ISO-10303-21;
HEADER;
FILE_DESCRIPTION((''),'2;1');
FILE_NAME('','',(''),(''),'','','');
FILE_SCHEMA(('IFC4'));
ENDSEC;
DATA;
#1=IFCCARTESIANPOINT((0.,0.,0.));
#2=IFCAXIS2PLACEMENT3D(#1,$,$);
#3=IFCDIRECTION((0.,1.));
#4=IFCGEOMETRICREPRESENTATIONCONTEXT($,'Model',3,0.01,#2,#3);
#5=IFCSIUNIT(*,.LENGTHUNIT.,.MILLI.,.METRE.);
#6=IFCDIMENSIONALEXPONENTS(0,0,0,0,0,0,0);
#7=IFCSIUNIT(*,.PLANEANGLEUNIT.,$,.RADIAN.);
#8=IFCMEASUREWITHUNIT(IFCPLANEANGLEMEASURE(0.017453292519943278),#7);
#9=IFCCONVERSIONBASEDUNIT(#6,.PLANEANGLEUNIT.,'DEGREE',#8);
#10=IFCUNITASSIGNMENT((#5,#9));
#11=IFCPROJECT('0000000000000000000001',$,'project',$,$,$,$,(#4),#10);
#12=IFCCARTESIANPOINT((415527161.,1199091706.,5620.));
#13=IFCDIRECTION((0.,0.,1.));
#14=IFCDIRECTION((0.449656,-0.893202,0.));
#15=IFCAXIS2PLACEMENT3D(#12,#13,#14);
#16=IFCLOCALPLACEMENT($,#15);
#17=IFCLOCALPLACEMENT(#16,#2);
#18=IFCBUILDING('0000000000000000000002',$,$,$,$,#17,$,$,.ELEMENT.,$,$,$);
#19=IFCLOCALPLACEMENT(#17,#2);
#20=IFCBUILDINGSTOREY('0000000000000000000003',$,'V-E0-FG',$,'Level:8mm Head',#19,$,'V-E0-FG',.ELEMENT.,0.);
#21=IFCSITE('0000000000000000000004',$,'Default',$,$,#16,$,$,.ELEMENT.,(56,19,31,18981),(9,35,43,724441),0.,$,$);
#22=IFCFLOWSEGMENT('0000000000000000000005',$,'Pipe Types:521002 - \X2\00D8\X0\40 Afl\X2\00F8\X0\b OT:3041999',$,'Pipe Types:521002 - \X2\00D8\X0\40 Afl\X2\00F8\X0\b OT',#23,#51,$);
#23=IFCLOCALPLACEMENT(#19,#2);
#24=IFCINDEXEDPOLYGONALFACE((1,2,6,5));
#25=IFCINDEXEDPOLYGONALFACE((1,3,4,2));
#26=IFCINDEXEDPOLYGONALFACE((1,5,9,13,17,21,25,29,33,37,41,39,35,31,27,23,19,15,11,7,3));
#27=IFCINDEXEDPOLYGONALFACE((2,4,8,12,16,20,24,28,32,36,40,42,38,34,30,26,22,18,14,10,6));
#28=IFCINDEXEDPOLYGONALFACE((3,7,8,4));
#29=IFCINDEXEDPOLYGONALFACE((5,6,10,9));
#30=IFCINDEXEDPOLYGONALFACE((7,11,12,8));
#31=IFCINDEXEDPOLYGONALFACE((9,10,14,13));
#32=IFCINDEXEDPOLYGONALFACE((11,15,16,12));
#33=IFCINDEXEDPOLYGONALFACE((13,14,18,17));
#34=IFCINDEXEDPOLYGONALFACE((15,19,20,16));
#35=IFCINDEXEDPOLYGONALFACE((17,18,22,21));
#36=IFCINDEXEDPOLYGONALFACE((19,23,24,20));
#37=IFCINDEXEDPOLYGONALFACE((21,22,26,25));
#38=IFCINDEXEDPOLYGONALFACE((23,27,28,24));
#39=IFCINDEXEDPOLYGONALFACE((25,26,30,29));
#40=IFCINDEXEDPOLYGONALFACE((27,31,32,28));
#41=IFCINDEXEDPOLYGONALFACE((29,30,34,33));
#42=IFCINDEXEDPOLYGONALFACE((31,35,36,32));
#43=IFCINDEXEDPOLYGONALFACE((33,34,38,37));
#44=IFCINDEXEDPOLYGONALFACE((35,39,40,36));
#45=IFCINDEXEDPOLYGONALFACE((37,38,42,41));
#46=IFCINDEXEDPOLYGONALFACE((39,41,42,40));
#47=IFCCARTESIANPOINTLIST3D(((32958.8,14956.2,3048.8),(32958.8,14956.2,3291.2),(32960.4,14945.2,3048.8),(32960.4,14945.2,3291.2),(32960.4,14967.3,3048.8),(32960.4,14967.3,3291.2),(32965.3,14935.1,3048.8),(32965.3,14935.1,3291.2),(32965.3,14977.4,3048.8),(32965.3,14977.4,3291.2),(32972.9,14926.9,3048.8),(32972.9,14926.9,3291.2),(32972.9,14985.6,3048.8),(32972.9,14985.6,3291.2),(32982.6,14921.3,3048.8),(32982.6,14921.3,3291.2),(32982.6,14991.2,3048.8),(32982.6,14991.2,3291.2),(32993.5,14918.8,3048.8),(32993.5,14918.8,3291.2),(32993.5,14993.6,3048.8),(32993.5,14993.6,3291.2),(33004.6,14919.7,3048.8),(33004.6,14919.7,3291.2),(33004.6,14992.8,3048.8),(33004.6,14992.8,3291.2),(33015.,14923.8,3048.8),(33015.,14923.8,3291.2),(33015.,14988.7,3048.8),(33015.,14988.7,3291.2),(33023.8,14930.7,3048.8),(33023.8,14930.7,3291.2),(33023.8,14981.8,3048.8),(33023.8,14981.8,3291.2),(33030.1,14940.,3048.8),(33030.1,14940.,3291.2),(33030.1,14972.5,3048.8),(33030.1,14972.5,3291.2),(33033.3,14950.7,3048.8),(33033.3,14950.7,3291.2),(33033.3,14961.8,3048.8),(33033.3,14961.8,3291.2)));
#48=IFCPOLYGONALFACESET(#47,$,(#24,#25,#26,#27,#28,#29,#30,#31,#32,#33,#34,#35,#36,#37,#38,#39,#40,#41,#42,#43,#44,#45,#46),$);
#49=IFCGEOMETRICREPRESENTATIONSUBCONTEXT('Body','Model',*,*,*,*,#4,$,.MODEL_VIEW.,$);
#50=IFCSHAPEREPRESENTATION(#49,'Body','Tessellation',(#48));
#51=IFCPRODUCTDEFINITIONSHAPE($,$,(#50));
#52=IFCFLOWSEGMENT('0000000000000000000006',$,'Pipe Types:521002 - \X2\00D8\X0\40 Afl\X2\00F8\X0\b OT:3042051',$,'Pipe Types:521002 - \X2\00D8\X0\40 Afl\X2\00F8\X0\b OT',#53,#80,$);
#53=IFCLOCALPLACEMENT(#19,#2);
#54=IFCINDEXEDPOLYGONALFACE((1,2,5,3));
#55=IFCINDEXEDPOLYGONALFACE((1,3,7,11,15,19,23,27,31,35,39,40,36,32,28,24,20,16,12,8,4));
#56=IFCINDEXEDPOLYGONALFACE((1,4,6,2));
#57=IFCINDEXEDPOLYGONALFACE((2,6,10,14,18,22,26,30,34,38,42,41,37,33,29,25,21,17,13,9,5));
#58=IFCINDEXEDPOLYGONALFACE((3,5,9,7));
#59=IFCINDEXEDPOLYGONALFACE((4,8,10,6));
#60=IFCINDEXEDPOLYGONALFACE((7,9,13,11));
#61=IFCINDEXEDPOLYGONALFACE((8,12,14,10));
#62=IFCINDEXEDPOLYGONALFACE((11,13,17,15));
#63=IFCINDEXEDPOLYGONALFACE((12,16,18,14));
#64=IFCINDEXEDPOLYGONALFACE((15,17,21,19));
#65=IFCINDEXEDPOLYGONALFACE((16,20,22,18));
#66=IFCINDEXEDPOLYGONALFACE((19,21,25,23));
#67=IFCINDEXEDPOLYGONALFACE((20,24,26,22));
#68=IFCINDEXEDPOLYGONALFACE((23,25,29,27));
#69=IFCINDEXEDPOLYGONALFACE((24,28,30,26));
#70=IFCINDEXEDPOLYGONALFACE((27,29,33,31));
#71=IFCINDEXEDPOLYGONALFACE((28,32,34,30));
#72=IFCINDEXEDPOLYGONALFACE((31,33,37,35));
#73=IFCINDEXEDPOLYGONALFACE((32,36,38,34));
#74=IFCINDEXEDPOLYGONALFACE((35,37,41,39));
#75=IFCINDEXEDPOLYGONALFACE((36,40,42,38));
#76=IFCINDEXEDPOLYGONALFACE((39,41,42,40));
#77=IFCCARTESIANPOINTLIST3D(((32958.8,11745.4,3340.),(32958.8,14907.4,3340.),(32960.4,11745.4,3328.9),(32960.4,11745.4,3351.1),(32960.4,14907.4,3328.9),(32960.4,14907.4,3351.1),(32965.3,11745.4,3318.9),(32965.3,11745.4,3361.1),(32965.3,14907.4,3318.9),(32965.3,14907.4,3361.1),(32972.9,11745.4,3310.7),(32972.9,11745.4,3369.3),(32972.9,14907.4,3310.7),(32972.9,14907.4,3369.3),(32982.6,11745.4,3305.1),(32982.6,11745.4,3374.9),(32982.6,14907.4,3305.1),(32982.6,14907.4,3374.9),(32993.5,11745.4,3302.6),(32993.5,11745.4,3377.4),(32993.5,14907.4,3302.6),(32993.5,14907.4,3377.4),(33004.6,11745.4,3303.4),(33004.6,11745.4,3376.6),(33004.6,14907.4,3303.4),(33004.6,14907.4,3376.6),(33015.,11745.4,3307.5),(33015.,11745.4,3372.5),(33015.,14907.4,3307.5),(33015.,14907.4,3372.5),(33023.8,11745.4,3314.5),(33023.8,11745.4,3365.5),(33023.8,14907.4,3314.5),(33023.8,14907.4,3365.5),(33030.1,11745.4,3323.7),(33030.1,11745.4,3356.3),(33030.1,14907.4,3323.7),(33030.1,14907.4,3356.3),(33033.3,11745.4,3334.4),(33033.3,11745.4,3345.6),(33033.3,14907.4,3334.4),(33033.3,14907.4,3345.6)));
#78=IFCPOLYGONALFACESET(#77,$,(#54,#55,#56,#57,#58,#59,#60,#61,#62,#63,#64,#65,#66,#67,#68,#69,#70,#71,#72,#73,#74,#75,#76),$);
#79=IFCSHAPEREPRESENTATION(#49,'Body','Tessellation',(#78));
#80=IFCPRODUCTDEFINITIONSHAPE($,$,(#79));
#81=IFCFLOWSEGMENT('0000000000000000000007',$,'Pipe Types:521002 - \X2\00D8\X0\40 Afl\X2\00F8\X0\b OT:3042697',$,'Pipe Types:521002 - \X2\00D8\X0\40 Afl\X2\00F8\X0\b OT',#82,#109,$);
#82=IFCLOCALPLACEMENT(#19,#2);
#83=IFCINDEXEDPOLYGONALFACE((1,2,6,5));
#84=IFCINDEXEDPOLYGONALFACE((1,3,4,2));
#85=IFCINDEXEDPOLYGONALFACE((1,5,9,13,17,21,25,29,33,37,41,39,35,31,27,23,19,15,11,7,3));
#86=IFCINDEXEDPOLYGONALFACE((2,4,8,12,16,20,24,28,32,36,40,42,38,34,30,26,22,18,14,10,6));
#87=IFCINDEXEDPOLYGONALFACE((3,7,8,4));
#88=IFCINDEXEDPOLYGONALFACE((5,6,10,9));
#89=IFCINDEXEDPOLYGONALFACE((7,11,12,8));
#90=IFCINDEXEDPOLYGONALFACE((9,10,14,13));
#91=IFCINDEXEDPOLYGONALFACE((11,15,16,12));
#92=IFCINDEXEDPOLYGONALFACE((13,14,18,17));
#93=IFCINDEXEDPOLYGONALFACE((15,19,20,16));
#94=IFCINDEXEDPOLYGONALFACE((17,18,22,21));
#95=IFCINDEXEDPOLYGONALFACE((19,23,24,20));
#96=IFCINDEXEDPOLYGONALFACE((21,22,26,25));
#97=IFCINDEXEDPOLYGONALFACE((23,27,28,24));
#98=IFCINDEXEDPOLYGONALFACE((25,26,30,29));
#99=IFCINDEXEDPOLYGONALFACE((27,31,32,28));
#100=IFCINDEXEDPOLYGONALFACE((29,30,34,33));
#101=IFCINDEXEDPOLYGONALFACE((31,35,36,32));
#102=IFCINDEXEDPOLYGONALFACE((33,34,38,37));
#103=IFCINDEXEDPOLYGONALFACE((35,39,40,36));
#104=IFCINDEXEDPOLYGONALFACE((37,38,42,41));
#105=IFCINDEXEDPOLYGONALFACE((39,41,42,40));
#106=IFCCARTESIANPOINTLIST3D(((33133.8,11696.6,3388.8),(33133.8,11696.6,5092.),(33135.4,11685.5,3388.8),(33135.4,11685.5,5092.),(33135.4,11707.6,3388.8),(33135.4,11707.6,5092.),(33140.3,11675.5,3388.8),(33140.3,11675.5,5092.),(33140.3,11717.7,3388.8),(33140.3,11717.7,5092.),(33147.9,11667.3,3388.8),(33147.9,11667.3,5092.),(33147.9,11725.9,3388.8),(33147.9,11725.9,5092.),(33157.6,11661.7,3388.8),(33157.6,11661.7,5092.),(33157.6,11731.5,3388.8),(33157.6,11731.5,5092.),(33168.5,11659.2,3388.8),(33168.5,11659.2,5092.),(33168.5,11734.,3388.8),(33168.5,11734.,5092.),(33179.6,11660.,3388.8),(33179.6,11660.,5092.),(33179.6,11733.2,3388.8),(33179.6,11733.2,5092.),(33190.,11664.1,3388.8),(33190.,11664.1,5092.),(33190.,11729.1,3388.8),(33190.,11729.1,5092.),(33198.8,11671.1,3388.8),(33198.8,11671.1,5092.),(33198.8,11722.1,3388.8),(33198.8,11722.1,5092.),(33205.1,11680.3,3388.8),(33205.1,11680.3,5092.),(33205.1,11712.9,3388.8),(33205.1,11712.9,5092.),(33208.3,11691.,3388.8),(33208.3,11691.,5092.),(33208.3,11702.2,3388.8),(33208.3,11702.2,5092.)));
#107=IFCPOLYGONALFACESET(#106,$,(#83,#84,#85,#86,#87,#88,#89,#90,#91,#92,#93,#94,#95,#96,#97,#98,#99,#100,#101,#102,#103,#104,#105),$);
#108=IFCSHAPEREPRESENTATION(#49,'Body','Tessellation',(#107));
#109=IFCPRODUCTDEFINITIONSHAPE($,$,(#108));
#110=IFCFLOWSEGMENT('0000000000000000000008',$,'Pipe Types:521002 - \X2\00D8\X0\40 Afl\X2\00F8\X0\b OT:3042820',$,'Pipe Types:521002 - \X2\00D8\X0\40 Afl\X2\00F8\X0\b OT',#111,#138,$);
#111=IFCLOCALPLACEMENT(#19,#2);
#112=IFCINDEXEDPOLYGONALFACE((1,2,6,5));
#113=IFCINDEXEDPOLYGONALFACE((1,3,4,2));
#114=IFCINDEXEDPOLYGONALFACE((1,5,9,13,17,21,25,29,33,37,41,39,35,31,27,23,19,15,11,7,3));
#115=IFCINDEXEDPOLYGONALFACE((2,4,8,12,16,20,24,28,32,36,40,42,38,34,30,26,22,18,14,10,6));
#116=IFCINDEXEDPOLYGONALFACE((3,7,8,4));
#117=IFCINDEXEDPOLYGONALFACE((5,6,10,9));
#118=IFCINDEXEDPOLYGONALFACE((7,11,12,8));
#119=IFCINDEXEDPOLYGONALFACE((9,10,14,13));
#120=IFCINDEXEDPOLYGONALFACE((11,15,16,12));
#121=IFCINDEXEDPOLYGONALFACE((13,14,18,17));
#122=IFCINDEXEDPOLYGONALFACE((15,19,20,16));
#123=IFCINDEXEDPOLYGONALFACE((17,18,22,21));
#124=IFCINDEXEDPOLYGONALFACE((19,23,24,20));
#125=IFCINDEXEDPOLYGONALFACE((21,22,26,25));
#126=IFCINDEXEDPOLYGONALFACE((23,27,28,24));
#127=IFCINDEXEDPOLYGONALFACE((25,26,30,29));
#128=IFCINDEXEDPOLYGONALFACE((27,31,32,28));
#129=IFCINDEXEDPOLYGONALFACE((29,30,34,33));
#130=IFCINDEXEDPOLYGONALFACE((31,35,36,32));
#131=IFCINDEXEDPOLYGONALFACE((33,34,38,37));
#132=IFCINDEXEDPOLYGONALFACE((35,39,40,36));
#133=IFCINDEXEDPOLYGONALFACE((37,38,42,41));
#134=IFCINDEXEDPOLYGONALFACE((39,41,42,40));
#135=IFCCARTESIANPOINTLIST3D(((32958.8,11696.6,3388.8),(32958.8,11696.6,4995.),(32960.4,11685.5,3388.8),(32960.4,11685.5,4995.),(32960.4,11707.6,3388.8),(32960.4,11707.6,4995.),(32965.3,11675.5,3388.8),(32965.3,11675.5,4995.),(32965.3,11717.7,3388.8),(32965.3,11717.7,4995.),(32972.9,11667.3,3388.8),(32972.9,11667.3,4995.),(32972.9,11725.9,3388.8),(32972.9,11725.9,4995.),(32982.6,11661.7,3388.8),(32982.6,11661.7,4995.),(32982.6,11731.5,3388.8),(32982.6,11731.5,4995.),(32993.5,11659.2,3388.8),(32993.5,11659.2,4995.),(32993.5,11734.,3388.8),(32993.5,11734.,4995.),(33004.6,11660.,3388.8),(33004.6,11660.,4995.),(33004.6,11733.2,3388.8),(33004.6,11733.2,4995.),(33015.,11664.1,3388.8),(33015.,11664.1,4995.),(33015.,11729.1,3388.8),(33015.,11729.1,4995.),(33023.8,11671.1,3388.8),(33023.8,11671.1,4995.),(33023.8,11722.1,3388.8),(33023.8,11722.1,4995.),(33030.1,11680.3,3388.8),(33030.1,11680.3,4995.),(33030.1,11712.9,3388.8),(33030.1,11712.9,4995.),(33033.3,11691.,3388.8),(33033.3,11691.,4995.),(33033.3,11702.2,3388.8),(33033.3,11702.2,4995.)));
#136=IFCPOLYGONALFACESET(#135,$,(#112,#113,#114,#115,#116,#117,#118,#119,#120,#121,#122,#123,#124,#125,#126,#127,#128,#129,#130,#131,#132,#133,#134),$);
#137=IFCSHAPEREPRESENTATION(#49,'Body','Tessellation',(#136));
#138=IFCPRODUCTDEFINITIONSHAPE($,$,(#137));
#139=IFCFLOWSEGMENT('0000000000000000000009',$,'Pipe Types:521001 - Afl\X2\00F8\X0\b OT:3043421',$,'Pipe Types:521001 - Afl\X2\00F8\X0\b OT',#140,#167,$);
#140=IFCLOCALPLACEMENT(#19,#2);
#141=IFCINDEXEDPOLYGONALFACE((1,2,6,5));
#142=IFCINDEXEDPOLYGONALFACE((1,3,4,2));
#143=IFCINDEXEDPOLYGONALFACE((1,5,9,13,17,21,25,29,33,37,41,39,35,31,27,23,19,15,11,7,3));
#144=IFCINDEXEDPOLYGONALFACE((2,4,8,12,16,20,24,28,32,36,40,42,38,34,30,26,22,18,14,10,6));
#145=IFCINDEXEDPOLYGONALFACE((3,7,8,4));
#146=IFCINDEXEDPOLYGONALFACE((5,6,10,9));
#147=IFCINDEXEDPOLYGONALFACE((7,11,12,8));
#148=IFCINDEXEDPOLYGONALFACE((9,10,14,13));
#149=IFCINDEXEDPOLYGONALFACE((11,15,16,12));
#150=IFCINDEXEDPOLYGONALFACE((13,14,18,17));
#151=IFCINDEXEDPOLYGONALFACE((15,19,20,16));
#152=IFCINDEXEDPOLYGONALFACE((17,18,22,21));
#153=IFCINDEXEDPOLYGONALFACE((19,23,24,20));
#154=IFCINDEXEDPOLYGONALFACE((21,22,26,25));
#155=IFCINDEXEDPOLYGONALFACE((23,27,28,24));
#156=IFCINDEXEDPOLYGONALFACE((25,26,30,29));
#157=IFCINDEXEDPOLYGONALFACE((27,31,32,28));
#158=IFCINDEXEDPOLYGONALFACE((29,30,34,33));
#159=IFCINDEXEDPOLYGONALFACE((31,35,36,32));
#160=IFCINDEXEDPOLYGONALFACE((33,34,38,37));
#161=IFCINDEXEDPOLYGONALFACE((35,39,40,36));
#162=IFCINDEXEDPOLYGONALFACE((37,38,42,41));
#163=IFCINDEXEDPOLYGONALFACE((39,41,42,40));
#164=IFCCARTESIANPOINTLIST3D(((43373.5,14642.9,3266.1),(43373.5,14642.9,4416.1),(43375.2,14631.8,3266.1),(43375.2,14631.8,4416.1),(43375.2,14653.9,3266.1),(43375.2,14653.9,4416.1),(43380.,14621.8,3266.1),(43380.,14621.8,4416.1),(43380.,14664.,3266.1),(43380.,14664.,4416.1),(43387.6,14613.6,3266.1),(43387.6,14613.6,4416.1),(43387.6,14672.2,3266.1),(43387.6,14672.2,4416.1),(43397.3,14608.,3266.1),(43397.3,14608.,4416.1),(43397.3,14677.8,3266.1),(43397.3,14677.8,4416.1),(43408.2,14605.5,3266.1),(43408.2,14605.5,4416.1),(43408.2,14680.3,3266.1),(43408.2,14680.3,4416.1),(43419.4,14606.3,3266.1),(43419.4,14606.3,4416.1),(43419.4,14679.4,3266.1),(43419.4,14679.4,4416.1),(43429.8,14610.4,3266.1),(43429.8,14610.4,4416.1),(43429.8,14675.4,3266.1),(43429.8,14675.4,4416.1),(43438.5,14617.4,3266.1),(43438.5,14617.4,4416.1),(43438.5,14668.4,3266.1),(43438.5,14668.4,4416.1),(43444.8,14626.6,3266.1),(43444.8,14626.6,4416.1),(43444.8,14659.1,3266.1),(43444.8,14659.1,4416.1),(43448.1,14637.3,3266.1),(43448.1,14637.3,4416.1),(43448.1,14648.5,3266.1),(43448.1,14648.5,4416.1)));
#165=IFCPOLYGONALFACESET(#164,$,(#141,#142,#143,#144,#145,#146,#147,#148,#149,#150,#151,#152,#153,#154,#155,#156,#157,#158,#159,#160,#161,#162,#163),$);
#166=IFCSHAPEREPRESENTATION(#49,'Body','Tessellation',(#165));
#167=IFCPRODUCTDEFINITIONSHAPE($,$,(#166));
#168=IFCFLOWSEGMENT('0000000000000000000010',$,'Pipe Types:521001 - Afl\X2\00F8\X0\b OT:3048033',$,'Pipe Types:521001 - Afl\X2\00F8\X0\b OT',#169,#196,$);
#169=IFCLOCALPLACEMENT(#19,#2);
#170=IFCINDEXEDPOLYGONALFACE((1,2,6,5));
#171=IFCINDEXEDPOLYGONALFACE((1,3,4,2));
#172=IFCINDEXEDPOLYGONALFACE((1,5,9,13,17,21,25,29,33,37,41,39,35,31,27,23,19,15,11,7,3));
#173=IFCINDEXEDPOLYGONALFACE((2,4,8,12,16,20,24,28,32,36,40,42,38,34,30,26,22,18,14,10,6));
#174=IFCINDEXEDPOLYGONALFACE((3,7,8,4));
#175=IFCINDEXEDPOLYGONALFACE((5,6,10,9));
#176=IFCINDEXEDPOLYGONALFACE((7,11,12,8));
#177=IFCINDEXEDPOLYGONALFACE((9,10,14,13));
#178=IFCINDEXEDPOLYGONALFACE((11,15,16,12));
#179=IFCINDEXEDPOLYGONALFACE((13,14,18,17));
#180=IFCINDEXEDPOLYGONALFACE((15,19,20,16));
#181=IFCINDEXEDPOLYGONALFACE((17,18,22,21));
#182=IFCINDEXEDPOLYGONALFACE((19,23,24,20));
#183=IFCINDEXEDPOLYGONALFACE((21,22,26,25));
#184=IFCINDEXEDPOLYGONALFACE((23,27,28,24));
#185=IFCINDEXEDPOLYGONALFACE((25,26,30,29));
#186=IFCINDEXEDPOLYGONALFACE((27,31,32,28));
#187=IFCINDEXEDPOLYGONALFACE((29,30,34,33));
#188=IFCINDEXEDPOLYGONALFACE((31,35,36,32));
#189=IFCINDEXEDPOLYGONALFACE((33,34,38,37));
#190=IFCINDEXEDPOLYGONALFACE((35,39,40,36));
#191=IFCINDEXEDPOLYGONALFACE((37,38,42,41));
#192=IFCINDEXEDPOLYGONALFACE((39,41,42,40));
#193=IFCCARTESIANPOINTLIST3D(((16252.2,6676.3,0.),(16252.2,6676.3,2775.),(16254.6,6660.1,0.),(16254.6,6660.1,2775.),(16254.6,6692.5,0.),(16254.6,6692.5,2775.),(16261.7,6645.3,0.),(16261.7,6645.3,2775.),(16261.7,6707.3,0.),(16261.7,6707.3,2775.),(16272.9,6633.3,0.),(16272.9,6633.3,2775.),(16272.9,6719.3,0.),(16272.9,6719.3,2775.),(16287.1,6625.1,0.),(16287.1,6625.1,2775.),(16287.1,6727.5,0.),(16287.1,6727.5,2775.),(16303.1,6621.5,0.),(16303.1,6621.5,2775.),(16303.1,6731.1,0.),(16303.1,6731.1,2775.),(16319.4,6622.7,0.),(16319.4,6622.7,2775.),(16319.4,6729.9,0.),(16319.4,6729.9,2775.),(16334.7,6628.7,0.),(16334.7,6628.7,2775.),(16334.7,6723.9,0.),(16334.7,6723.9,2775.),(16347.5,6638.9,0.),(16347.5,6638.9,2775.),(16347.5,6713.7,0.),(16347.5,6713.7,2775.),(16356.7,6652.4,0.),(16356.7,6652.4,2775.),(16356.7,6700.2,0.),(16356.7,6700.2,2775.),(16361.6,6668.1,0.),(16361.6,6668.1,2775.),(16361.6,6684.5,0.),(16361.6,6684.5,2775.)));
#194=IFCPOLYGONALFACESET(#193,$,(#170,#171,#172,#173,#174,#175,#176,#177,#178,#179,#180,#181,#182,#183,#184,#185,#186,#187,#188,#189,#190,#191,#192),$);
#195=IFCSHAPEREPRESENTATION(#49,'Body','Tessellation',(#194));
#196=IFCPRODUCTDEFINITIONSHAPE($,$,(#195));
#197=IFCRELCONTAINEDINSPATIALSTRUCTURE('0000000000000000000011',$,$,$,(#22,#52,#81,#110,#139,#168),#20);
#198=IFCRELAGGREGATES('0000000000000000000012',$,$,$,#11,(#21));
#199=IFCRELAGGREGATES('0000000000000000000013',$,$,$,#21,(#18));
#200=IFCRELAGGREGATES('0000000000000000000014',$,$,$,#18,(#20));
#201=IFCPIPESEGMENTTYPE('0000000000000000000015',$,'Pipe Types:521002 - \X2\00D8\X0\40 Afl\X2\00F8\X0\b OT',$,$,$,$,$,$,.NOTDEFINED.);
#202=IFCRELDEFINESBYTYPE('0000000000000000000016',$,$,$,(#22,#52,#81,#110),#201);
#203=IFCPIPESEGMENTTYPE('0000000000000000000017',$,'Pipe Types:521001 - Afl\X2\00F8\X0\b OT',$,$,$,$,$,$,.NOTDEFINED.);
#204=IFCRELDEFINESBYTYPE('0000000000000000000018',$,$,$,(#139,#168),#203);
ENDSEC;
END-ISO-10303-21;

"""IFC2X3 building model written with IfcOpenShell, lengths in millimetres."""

from ifc_helpers import new_model, entity, si_unit, converted_unit, direction, frame, frame_2d, origin, origin_2d_with_axis, place, context, subcontext, project, spatial, circle, extrude, type_object, element, save


model = new_model("IFC2X3")

# Units and contexts
model_context = context("Model", 3, precision=0.01, world=origin(), true_north=direction((0.0, 1.0)))
body_context = subcontext(model_context, "Body", "Model", "MODEL_VIEW")
ifc_project = project(units=[si_unit("LENGTHUNIT", "METRE", prefix="MILLI"), converted_unit("PLANEANGLEUNIT", "DEGREE", entity("IfcPlaneAngleMeasure", 0.017453292519943278), si_unit("PLANEANGLEUNIT", "RADIAN"), dimensions=[0, 0, 0, 0, 0, 0, 0])], contexts=[model_context])

# Site, building, storey
site_placement = place(None, frame((415527161.0, 1199091706.0, 5620.0), z_axis=(0.0, 0.0, 1.0), x_axis=(0.449656, -0.893202, 0.0)))
site = spatial("IfcSite", under=ifc_project, at=site_placement, Name="Default", CompositionType="ELEMENT", RefLatitude=(56, 19, 31, 18981), RefLongitude=(9, 35, 43, 724441), RefElevation=0.0)
building_placement = place(site_placement, origin())
building = spatial("IfcBuilding", under=site, at=building_placement, CompositionType="ELEMENT")
storey_placement = place(building_placement, origin())
storey = spatial("IfcBuildingStorey", under=building, at=storey_placement, Name="V-E0-FG", ObjectType="Level:8mm Head", LongName="V-E0-FG", CompositionType="ELEMENT", Elevation=0.0)

# Flow segments
pipe_segment_type_1 = type_object("IfcPipeSegmentType", Name="Pipe Types:521002 - Ø40 Afløb OT", PredefinedType="NOTDEFINED")
flow_segment_1_placement = place(storey_placement, origin())
element("IfcFlowSegment", 1, at=flow_segment_1_placement, inside=storey, type_object=pipe_segment_type_1, Name="Pipe Types:521002 - Ø40 Afløb OT:3041999", ObjectType="Pipe Types:521002 - Ø40 Afløb OT", context=body_context, shape_type="SweptSolid", body=[
    extrude(circle(Radius=37.5, at=origin_2d_with_axis()), frame((32996.3, 14956.2, 3048.8), z_axis=(0.0, 0.0, 1.0), x_axis=(-1.0, 0.0, 0.0)), (0.0, 0.0, 1.0), 242.3),
])
flow_segment_2_placement = place(storey_placement, origin())
element("IfcFlowSegment", 2, at=flow_segment_2_placement, inside=storey, type_object=pipe_segment_type_1, Name="Pipe Types:521002 - Ø40 Afløb OT:3042051", ObjectType="Pipe Types:521002 - Ø40 Afløb OT", context=body_context, shape_type="SweptSolid", body=[
    extrude(circle(Radius=37.5, at=frame_2d((0.0, 0.0), x_axis=(1.0, 0.0))), frame((32996.3, 11745.4, 3340.0), z_axis=(0.0, 1.0, 0.0), x_axis=(-1.0, 0.0, 0.0)), (0.0, 0.0, 1.0), 3161.9),
])
flow_segment_3_placement = place(storey_placement, origin())
element("IfcFlowSegment", 3, at=flow_segment_3_placement, inside=storey, type_object=pipe_segment_type_1, Name="Pipe Types:521002 - Ø40 Afløb OT:3042697", ObjectType="Pipe Types:521002 - Ø40 Afløb OT", context=body_context, shape_type="SweptSolid", body=[
    extrude(circle(Radius=37.5, at=origin_2d_with_axis()), frame((33171.3, 11696.6, 3388.8), z_axis=(0.0, 0.0, 1.0), x_axis=(-1.0, 0.0, 0.0)), (0.0, 0.0, 1.0), 1703.1),
])
flow_segment_4_placement = place(storey_placement, origin())
element("IfcFlowSegment", 4, at=flow_segment_4_placement, inside=storey, type_object=pipe_segment_type_1, Name="Pipe Types:521002 - Ø40 Afløb OT:3042820", ObjectType="Pipe Types:521002 - Ø40 Afløb OT", context=body_context, shape_type="SweptSolid", body=[
    extrude(circle(Radius=37.5, at=origin_2d_with_axis()), frame((32996.3, 11696.6, 3388.8), z_axis=(0.0, 0.0, 1.0), x_axis=(-1.0, 0.0, 0.0)), (0.0, 0.0, 1.0), 1606.1),
])
pipe_segment_type_2 = type_object("IfcPipeSegmentType", Name="Pipe Types:521001 - Afløb OT", PredefinedType="NOTDEFINED")
flow_segment_5_placement = place(storey_placement, origin())
element("IfcFlowSegment", 5, at=flow_segment_5_placement, inside=storey, type_object=pipe_segment_type_2, Name="Pipe Types:521001 - Afløb OT:3043421", ObjectType="Pipe Types:521001 - Afløb OT", context=body_context, shape_type="SweptSolid", body=[
    extrude(circle(Radius=37.5, at=origin_2d_with_axis()), frame((43411.0, 14642.9, 3266.1), z_axis=(0.0, 0.0, 1.0), x_axis=(-1.0, 0.0, 0.0)), (0.0, 0.0, 1.0), 1150.0),
])
flow_segment_6_placement = place(storey_placement, origin())
element("IfcFlowSegment", 6, at=flow_segment_6_placement, inside=storey, type_object=pipe_segment_type_2, Name="Pipe Types:521001 - Afløb OT:3048033", ObjectType="Pipe Types:521001 - Afløb OT", context=body_context, shape_type="SweptSolid", body=[
    extrude(circle(Radius=55.0, at=origin_2d_with_axis()), frame((16307.2, 6676.3, 0.0), z_axis=(0.0, 0.0, 1.0), x_axis=(-1.0, 0.0, 0.0)), (0.0, 0.0, 1.0), 2775.0),
])

save(model, "model.ifc")
